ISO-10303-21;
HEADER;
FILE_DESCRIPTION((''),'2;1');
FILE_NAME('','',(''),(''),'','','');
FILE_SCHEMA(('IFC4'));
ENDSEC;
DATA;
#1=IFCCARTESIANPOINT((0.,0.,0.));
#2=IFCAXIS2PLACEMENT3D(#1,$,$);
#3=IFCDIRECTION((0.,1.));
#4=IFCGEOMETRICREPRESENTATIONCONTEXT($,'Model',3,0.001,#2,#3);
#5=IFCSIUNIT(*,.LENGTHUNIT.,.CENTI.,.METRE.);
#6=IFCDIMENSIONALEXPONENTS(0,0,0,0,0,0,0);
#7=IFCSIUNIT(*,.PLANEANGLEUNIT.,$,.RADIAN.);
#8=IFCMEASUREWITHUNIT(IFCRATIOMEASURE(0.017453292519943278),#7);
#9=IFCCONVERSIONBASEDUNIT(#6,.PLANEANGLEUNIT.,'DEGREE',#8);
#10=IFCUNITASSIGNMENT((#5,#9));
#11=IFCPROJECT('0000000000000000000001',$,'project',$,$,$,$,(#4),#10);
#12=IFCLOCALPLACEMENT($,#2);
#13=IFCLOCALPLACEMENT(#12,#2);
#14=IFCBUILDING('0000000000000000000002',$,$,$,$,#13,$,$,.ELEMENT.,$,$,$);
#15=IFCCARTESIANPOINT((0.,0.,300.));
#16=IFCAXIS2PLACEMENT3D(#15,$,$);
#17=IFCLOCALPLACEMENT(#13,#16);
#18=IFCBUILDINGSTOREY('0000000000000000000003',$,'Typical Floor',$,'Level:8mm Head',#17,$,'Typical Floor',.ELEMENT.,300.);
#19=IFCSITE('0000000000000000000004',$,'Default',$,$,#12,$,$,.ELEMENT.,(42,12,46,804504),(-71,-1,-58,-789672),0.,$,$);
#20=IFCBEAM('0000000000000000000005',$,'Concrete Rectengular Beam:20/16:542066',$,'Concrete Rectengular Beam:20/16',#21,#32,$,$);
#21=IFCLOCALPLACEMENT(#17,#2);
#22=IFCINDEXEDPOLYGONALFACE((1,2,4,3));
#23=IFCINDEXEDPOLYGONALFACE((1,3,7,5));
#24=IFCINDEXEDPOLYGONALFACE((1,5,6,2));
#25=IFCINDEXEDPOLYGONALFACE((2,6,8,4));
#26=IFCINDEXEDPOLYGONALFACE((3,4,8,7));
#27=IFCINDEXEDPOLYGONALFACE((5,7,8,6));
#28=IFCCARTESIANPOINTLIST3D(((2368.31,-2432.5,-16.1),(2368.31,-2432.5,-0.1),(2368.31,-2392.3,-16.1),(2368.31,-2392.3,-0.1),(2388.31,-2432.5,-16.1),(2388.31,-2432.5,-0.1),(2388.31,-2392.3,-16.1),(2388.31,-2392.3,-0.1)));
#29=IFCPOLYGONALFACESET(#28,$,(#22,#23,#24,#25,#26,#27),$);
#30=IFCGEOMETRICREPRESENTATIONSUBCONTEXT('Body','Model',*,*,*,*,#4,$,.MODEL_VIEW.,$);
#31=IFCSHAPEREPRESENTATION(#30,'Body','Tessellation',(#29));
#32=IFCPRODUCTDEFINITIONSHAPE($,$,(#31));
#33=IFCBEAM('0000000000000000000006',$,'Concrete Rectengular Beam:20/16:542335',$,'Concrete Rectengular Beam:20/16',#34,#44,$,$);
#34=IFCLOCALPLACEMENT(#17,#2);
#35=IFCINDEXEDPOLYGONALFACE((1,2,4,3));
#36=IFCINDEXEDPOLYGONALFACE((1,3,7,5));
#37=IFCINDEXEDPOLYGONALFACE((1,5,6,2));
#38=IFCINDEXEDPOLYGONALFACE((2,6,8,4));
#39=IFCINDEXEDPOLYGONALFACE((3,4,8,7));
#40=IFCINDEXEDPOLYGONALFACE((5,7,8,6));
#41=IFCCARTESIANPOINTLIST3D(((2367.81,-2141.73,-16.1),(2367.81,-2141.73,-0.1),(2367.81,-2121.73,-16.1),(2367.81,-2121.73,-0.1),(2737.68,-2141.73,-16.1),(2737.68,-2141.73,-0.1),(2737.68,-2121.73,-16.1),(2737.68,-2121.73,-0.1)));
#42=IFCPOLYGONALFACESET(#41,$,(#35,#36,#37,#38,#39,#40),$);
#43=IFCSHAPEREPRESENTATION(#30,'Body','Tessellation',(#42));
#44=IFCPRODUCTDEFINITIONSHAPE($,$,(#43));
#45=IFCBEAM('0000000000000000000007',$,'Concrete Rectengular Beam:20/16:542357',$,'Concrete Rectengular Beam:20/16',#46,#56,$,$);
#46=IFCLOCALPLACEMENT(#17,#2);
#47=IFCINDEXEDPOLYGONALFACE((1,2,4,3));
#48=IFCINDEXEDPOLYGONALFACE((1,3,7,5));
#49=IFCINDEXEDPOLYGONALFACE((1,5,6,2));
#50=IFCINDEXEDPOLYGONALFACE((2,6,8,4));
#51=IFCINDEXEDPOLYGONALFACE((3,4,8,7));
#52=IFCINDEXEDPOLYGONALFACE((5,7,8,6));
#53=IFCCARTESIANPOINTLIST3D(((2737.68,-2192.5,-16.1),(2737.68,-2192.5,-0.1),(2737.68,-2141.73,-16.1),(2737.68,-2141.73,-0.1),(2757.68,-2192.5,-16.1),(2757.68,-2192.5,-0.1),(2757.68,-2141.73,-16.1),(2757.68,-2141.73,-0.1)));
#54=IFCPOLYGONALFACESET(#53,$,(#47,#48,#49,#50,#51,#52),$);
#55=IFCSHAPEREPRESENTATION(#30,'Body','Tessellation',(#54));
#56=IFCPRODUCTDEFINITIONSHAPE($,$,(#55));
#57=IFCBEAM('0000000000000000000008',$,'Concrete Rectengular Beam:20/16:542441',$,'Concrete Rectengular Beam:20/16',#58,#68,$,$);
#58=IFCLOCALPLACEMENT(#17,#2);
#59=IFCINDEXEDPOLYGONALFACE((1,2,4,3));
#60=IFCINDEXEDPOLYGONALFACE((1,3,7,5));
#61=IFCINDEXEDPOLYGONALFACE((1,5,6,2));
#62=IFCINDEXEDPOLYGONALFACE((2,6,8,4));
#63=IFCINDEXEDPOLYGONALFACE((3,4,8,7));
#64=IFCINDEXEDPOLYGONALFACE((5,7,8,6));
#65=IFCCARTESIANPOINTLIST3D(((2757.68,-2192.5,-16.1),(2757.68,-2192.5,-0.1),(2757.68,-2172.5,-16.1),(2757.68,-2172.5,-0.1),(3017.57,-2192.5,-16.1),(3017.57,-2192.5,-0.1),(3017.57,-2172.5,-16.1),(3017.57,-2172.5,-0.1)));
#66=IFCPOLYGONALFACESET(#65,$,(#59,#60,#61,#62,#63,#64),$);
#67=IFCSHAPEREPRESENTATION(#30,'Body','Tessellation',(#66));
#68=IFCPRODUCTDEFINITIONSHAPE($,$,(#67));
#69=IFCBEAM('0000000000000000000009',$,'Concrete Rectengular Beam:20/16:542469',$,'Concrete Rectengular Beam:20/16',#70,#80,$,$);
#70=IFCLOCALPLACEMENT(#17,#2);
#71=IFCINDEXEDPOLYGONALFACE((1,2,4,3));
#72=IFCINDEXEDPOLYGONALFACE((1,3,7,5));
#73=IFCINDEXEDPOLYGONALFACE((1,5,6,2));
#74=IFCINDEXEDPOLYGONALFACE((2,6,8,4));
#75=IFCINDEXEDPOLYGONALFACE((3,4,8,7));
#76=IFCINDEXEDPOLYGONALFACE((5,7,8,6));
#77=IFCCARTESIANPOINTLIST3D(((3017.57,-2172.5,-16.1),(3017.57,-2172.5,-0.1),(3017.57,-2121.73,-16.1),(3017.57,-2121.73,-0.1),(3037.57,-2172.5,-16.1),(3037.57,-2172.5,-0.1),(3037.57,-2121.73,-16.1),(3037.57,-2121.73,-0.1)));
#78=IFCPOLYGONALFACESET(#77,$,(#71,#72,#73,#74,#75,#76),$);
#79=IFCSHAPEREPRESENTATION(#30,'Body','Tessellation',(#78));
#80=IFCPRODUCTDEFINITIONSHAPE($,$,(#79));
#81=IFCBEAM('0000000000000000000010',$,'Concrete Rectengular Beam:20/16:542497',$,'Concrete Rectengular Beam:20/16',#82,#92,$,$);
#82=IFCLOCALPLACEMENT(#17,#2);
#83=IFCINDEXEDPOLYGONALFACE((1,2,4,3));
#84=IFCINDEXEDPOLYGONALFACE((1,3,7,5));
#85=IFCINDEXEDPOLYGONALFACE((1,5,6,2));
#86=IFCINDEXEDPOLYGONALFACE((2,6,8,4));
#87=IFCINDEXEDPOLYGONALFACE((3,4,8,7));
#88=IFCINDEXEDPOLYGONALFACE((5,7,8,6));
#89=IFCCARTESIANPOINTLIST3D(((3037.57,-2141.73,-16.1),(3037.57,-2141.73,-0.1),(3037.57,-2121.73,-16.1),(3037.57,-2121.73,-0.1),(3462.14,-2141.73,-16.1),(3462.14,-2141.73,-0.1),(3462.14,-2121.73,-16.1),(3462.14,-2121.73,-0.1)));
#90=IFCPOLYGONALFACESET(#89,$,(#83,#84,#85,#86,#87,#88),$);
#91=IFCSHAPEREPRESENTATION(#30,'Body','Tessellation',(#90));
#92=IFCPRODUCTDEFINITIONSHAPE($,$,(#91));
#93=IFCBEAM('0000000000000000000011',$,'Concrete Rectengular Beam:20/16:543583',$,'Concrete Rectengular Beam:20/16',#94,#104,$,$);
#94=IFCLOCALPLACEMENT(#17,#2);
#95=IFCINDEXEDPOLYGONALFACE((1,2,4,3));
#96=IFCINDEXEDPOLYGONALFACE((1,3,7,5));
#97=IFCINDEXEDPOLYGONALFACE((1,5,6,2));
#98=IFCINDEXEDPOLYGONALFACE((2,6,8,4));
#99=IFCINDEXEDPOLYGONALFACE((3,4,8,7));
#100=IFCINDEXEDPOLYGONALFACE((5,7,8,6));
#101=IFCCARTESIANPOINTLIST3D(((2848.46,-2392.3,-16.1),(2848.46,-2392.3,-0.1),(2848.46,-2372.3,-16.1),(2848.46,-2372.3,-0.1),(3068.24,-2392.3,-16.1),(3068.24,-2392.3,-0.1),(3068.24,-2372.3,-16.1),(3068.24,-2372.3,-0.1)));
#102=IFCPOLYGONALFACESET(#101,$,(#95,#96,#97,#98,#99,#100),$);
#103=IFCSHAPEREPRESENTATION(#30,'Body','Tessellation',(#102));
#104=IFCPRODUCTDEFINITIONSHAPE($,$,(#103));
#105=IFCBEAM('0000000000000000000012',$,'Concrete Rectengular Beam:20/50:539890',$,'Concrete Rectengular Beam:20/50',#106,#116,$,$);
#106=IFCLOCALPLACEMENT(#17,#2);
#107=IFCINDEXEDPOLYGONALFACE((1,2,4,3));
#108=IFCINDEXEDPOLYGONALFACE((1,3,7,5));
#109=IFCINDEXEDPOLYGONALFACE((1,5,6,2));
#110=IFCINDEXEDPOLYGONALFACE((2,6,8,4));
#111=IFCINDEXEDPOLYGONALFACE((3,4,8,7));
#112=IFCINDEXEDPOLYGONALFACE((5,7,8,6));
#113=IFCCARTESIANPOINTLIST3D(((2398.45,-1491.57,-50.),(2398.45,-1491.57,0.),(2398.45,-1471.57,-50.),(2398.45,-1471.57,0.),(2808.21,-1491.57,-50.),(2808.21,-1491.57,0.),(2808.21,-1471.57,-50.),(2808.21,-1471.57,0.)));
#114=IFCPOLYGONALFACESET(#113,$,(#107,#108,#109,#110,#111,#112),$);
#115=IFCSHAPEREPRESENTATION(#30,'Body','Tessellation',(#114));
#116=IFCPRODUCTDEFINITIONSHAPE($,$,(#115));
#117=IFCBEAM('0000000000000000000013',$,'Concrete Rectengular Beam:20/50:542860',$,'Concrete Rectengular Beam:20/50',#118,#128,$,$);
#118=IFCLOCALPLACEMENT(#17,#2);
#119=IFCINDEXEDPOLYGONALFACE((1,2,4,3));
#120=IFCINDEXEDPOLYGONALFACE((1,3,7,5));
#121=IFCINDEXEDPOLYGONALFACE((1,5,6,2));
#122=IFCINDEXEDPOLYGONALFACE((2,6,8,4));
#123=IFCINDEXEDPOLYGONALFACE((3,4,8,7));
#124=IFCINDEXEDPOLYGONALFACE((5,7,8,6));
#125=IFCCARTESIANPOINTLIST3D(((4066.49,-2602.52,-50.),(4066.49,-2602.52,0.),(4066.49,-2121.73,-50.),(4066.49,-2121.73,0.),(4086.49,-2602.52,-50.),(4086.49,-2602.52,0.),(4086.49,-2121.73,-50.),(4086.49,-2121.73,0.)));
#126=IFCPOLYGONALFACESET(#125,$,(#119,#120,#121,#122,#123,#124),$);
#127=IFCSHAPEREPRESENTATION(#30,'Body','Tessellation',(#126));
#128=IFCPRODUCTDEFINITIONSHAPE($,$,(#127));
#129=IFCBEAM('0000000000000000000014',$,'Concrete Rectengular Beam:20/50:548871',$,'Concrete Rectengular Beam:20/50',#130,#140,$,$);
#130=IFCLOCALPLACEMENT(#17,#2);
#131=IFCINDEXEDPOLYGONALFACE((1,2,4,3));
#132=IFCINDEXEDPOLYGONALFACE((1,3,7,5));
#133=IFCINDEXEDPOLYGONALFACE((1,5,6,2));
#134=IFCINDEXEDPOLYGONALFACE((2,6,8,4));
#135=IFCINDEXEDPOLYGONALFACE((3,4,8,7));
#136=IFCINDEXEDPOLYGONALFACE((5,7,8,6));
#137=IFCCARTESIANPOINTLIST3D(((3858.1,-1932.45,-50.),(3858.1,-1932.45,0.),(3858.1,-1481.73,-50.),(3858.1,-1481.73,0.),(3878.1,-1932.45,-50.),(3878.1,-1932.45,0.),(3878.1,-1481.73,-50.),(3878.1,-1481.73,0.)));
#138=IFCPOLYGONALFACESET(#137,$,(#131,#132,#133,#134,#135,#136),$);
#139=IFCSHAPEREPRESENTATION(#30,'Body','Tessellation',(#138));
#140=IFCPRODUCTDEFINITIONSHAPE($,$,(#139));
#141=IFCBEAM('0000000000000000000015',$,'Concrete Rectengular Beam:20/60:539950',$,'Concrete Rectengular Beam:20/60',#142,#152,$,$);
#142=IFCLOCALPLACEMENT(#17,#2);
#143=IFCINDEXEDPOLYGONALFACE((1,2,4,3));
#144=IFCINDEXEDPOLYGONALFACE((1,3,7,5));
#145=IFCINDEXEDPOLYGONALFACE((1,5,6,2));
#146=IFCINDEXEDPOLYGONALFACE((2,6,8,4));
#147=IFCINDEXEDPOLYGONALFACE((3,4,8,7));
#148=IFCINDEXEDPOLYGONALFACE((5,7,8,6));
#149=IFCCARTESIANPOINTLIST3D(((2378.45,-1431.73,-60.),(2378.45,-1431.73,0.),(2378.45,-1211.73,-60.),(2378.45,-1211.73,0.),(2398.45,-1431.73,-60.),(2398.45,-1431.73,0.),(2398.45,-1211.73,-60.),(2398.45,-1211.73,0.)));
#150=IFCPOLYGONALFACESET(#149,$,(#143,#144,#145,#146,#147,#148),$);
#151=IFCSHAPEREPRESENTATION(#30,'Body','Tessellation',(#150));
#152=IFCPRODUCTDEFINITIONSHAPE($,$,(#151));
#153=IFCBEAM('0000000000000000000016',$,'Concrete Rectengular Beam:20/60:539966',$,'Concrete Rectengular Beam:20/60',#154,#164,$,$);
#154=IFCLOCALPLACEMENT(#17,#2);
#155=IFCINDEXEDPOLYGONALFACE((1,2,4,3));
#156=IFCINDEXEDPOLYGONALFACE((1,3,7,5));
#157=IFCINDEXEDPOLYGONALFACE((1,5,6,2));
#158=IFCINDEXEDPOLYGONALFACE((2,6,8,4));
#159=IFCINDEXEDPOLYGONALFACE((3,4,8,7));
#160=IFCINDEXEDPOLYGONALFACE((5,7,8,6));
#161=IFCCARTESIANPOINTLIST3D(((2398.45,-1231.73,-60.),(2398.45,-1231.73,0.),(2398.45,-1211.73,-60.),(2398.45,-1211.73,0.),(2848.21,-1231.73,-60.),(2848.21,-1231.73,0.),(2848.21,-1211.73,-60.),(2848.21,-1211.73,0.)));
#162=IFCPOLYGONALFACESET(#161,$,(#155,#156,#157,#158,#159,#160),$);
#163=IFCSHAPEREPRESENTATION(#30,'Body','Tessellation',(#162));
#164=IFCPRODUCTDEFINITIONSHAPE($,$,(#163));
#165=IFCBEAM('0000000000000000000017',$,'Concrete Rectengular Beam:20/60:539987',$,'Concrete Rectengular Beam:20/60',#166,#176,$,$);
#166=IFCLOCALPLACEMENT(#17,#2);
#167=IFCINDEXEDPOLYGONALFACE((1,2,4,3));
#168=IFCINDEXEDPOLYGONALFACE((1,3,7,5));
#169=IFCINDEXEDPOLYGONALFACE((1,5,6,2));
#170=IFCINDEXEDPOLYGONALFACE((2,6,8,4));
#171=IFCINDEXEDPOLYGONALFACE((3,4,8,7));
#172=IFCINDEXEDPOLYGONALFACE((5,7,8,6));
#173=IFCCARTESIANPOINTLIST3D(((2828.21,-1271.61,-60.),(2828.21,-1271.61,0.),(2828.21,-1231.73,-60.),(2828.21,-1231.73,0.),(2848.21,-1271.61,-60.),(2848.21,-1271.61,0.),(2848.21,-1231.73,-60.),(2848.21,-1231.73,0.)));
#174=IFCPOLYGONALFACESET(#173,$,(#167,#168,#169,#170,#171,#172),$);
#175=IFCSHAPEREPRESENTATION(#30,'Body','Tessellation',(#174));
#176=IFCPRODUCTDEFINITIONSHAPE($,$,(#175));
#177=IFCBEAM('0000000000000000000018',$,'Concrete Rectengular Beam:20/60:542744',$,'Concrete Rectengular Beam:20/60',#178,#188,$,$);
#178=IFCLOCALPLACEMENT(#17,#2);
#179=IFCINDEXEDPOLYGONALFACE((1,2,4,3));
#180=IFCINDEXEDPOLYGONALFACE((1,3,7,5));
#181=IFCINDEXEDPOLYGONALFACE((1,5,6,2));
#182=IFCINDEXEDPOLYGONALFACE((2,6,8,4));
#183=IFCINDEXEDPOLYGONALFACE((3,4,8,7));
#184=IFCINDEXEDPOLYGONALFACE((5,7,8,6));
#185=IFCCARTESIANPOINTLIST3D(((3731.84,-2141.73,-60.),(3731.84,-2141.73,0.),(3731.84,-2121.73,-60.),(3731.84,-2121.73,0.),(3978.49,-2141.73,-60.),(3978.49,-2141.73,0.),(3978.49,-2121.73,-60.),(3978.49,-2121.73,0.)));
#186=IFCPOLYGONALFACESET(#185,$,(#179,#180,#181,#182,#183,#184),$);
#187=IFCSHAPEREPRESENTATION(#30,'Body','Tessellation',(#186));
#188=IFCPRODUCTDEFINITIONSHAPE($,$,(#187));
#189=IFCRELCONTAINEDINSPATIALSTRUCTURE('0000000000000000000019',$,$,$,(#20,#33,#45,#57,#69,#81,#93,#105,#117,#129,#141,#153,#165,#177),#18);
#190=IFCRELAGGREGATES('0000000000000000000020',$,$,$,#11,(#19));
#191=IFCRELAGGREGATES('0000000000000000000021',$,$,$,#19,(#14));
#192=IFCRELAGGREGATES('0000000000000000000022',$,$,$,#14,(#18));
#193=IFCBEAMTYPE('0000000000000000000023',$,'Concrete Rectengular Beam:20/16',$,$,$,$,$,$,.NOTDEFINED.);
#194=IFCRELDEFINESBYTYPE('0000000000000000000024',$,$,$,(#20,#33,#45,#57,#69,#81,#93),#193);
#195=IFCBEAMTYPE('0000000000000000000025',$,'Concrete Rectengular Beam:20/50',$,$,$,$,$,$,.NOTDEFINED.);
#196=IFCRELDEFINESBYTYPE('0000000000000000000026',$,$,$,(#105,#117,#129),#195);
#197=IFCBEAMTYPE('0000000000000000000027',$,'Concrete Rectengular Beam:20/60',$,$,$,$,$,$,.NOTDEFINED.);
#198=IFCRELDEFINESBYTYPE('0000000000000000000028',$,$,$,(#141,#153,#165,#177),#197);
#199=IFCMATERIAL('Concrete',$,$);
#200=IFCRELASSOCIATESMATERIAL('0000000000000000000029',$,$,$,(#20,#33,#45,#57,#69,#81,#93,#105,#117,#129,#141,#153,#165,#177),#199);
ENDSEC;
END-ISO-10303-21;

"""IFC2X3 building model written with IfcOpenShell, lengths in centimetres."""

from ifc_helpers import new_model, entity, si_unit, converted_unit, direction, frame, frame_2d, origin, origin_2d_with_axis, place, context, subcontext, project, spatial, rectangle, extrude, material, type_object, element, save


model = new_model("IFC2X3")

# Units and contexts
model_context = context("Model", 3, precision=0.001, world=origin(), true_north=direction((0.0, 1.0)))
body_context = subcontext(model_context, "Body", "Model", "MODEL_VIEW")
ifc_project = project(units=[si_unit("LENGTHUNIT", "METRE", prefix="CENTI"), converted_unit("PLANEANGLEUNIT", "DEGREE", entity("IfcRatioMeasure", 0.017453292519943278), si_unit("PLANEANGLEUNIT", "RADIAN"), dimensions=[0, 0, 0, 0, 0, 0, 0])], contexts=[model_context])

# Site, building, storey
site_placement = place(None, origin())
site = spatial("IfcSite", under=ifc_project, at=site_placement, Name="Default", CompositionType="ELEMENT", RefLatitude=(42, 12, 46, 804504), RefLongitude=(-71, -1, -58, -789672), RefElevation=0.0)
building_placement = place(site_placement, origin())
building = spatial("IfcBuilding", under=site, at=building_placement, CompositionType="ELEMENT")
storey_placement = place(building_placement, frame((0.0, 0.0, 300.0)))
storey = spatial("IfcBuildingStorey", under=building, at=storey_placement, Name="Typical Floor", ObjectType="Level:8mm Head", LongName="Typical Floor", CompositionType="ELEMENT", Elevation=300.0)

# Beams
ifc_material = material(Name="Concrete")
beam_type_1 = type_object("IfcBeamType", Name="Concrete Rectengular Beam:20/16", PredefinedType="NOTDEFINED")
beam_1_placement = place(storey_placement, frame((2378.31, -2382.3, 0.0), z_axis=(0.0, 0.0, 1.0), x_axis=(0.0, -1.0, 0.0)))
element("IfcBeam", 1, at=beam_1_placement, inside=storey, type_object=beam_type_1, material=ifc_material, Name="Concrete Rectengular Beam:20/16:542066", ObjectType="Concrete Rectengular Beam:20/16", context=body_context, shape_type="SweptSolid", body=[
    extrude(rectangle(XDim=16.0, YDim=20.0, at=frame_2d((0.0, 0.0), x_axis=(1.0, 0.0))), frame((10.0, 0.0, -8.1), z_axis=(1.0, 0.0, 0.0), x_axis=(0.0, 0.0, -1.0)), (0.0, 0.0, 1.0), 40.21),
])
beam_2_placement = place(storey_placement, frame((2357.81, -2131.73, 0.0)))
element("IfcBeam", 2, at=beam_2_placement, inside=storey, type_object=beam_type_1, material=ifc_material, Name="Concrete Rectengular Beam:20/16:542335", ObjectType="Concrete Rectengular Beam:20/16", context=body_context, shape_type="SweptSolid", body=[
    extrude(rectangle(XDim=16.0, YDim=20.0, at=frame_2d((0.0, 0.0), x_axis=(1.0, 0.0))), frame((10.0, 0.0, -8.1), z_axis=(1.0, 0.0, 0.0), x_axis=(0.0, 0.0, -1.0)), (0.0, 0.0, 1.0), 369.88),
])
beam_3_placement = place(storey_placement, frame((2747.68, -2131.73, 0.0), z_axis=(0.0, 0.0, 1.0), x_axis=(0.0, -1.0, 0.0)))
element("IfcBeam", 3, at=beam_3_placement, inside=storey, type_object=beam_type_1, material=ifc_material, Name="Concrete Rectengular Beam:20/16:542357", ObjectType="Concrete Rectengular Beam:20/16", context=body_context, shape_type="SweptSolid", body=[
    extrude(rectangle(XDim=16.0, YDim=20.0, at=frame_2d((0.0, 0.0), x_axis=(1.0, 0.0))), frame((10.0, 0.0, -8.1), z_axis=(1.0, 0.0, 0.0), x_axis=(0.0, 0.0, -1.0)), (0.0, 0.0, 1.0), 50.77),
])
beam_4_placement = place(storey_placement, frame((3027.57, -2182.5, 0.0), z_axis=(0.0, 0.0, 1.0), x_axis=(-1.0, 0.0, 0.0)))
element("IfcBeam", 4, at=beam_4_placement, inside=storey, type_object=beam_type_1, material=ifc_material, Name="Concrete Rectengular Beam:20/16:542441", ObjectType="Concrete Rectengular Beam:20/16", context=body_context, shape_type="SweptSolid", body=[
    extrude(rectangle(XDim=16.0, YDim=20.0, at=frame_2d((0.0, 0.0), x_axis=(1.0, 0.0))), frame((10.0, 0.0, -8.1), z_axis=(1.0, 0.0, 0.0), x_axis=(0.0, 0.0, -1.0)), (0.0, 0.0, 1.0), 259.89),
])
beam_5_placement = place(storey_placement, frame((3027.57, -2182.5, 0.0), z_axis=(0.0, 0.0, 1.0), x_axis=(0.0, 1.0, 0.0)))
element("IfcBeam", 5, at=beam_5_placement, inside=storey, type_object=beam_type_1, material=ifc_material, Name="Concrete Rectengular Beam:20/16:542469", ObjectType="Concrete Rectengular Beam:20/16", context=body_context, shape_type="SweptSolid", body=[
    extrude(rectangle(XDim=16.0, YDim=20.0, at=frame_2d((0.0, 0.0), x_axis=(1.0, 0.0))), frame((10.0, 0.0, -8.1), z_axis=(1.0, 0.0, 0.0), x_axis=(0.0, 0.0, -1.0)), (0.0, 0.0, 1.0), 50.77),
])
beam_6_placement = place(storey_placement, frame((3027.57, -2131.73, 0.0)))
element("IfcBeam", 6, at=beam_6_placement, inside=storey, type_object=beam_type_1, material=ifc_material, Name="Concrete Rectengular Beam:20/16:542497", ObjectType="Concrete Rectengular Beam:20/16", context=body_context, shape_type="SweptSolid", body=[
    extrude(rectangle(XDim=16.0, YDim=20.0, at=frame_2d((0.0, 0.0), x_axis=(1.0, 0.0))), frame((10.0, 0.0, -8.1), z_axis=(1.0, 0.0, 0.0), x_axis=(0.0, 0.0, -1.0)), (0.0, 0.0, 1.0), 424.57),
])
beam_7_placement = place(storey_placement, frame((3078.24, -2382.3, 0.0), z_axis=(0.0, 0.0, 1.0), x_axis=(-1.0, 0.0, 0.0)))
element("IfcBeam", 7, at=beam_7_placement, inside=storey, type_object=beam_type_1, material=ifc_material, Name="Concrete Rectengular Beam:20/16:543583", ObjectType="Concrete Rectengular Beam:20/16", context=body_context, shape_type="SweptSolid", body=[
    extrude(rectangle(XDim=16.0, YDim=20.0, at=frame_2d((0.0, 0.0), x_axis=(1.0, 0.0))), frame((10.0, 0.0, -8.1), z_axis=(1.0, 0.0, 0.0), x_axis=(0.0, 0.0, -1.0)), (0.0, 0.0, 1.0), 219.77),
])
beam_type_2 = type_object("IfcBeamType", Name="Concrete Rectengular Beam:20/50", PredefinedType="NOTDEFINED")
beam_8_placement = place(storey_placement, frame((2388.45, -1481.57, 0.0)))
element("IfcBeam", 8, at=beam_8_placement, inside=storey, type_object=beam_type_2, material=ifc_material, Name="Concrete Rectengular Beam:20/50:539890", ObjectType="Concrete Rectengular Beam:20/50", context=body_context, shape_type="SweptSolid", body=[
    extrude(rectangle(XDim=50.0, YDim=20.0, at=frame_2d((0.0, 0.0), x_axis=(1.0, 0.0))), frame((10.0, 0.0, -25.0), z_axis=(1.0, 0.0, 0.0), x_axis=(0.0, 0.0, -1.0)), (0.0, 0.0, 1.0), 409.76),
])
beam_9_placement = place(storey_placement, frame((4076.49, -2131.73, 0.0), z_axis=(0.0, 0.0, 1.0), x_axis=(0.0, -1.0, 0.0)))
element("IfcBeam", 9, at=beam_9_placement, inside=storey, type_object=beam_type_2, material=ifc_material, Name="Concrete Rectengular Beam:20/50:542860", ObjectType="Concrete Rectengular Beam:20/50", context=body_context, shape_type="SweptSolid", body=[
    extrude(rectangle(XDim=50.0, YDim=20.0, at=origin_2d_with_axis()), frame((-10.0, 0.0, -25.0), z_axis=(1.0, 0.0, 0.0), x_axis=(0.0, 0.0, -1.0)), (0.0, 0.0, 1.0), 480.79),
])
beam_10_placement = place(storey_placement, frame((3868.1, -1942.45, 0.0), z_axis=(0.0, 0.0, 1.0), x_axis=(0.0, 1.0, 0.0)))
element("IfcBeam", 10, at=beam_10_placement, inside=storey, type_object=beam_type_2, material=ifc_material, Name="Concrete Rectengular Beam:20/50:548871", ObjectType="Concrete Rectengular Beam:20/50", context=body_context, shape_type="SweptSolid", body=[
    extrude(rectangle(XDim=50.0, YDim=20.0, at=frame_2d((0.0, 0.0), x_axis=(1.0, 0.0))), frame((10.0, 0.0, -25.0), z_axis=(1.0, 0.0, 0.0), x_axis=(0.0, 0.0, -1.0)), (0.0, 0.0, 1.0), 450.73),
])
beam_type_3 = type_object("IfcBeamType", Name="Concrete Rectengular Beam:20/60", PredefinedType="NOTDEFINED")
beam_11_placement = place(storey_placement, frame((2388.45, -1461.73, 0.0), z_axis=(0.0, 0.0, 1.0), x_axis=(0.0, 1.0, 0.0)))
element("IfcBeam", 11, at=beam_11_placement, inside=storey, type_object=beam_type_3, material=ifc_material, Name="Concrete Rectengular Beam:20/60:539950", ObjectType="Concrete Rectengular Beam:20/60", context=body_context, shape_type="SweptSolid", body=[
    extrude(rectangle(XDim=60.0, YDim=20.0, at=frame_2d((0.0, 0.0), x_axis=(1.0, 0.0))), frame((30.0, 0.0, -30.0), z_axis=(1.0, 0.0, 0.0), x_axis=(0.0, 0.0, -1.0)), (0.0, 0.0, 1.0), 220.0),
])
beam_12_placement = place(storey_placement, frame((2388.45, -1221.73, 0.0)))
element("IfcBeam", 12, at=beam_12_placement, inside=storey, type_object=beam_type_3, material=ifc_material, Name="Concrete Rectengular Beam:20/60:539966", ObjectType="Concrete Rectengular Beam:20/60", context=body_context, shape_type="SweptSolid", body=[
    extrude(rectangle(XDim=60.0, YDim=20.0, at=frame_2d((0.0, 0.0), x_axis=(1.0, 0.0))), frame((10.0, 0.0, -30.0), z_axis=(1.0, 0.0, 0.0), x_axis=(0.0, 0.0, -1.0)), (0.0, 0.0, 1.0), 449.76),
])
beam_13_placement = place(storey_placement, frame((2838.21, -1221.73, 0.0), z_axis=(0.0, 0.0, 1.0), x_axis=(0.0, -1.0, 0.0)))
element("IfcBeam", 13, at=beam_13_placement, inside=storey, type_object=beam_type_3, material=ifc_material, Name="Concrete Rectengular Beam:20/60:539987", ObjectType="Concrete Rectengular Beam:20/60", context=body_context, shape_type="SweptSolid", body=[
    extrude(rectangle(XDim=60.0, YDim=20.0, at=frame_2d((0.0, 0.0), x_axis=(1.0, 0.0))), frame((10.0, 0.0, -30.0), z_axis=(1.0, 0.0, 0.0), x_axis=(0.0, 0.0, -1.0)), (0.0, 0.0, 1.0), 39.88),
])
beam_14_placement = place(storey_placement, frame((3721.84, -2131.73, 0.0)))
element("IfcBeam", 14, at=beam_14_placement, inside=storey, type_object=beam_type_3, material=ifc_material, Name="Concrete Rectengular Beam:20/60:542744", ObjectType="Concrete Rectengular Beam:20/60", context=body_context, shape_type="SweptSolid", body=[
    extrude(rectangle(XDim=60.0, YDim=20.0, at=frame_2d((0.0, 0.0), x_axis=(1.0, 0.0))), frame((10.0, 0.0, -30.0), z_axis=(1.0, 0.0, 0.0), x_axis=(0.0, 0.0, -1.0)), (0.0, 0.0, 1.0), 246.65),
])

save(model, "model.ifc")
